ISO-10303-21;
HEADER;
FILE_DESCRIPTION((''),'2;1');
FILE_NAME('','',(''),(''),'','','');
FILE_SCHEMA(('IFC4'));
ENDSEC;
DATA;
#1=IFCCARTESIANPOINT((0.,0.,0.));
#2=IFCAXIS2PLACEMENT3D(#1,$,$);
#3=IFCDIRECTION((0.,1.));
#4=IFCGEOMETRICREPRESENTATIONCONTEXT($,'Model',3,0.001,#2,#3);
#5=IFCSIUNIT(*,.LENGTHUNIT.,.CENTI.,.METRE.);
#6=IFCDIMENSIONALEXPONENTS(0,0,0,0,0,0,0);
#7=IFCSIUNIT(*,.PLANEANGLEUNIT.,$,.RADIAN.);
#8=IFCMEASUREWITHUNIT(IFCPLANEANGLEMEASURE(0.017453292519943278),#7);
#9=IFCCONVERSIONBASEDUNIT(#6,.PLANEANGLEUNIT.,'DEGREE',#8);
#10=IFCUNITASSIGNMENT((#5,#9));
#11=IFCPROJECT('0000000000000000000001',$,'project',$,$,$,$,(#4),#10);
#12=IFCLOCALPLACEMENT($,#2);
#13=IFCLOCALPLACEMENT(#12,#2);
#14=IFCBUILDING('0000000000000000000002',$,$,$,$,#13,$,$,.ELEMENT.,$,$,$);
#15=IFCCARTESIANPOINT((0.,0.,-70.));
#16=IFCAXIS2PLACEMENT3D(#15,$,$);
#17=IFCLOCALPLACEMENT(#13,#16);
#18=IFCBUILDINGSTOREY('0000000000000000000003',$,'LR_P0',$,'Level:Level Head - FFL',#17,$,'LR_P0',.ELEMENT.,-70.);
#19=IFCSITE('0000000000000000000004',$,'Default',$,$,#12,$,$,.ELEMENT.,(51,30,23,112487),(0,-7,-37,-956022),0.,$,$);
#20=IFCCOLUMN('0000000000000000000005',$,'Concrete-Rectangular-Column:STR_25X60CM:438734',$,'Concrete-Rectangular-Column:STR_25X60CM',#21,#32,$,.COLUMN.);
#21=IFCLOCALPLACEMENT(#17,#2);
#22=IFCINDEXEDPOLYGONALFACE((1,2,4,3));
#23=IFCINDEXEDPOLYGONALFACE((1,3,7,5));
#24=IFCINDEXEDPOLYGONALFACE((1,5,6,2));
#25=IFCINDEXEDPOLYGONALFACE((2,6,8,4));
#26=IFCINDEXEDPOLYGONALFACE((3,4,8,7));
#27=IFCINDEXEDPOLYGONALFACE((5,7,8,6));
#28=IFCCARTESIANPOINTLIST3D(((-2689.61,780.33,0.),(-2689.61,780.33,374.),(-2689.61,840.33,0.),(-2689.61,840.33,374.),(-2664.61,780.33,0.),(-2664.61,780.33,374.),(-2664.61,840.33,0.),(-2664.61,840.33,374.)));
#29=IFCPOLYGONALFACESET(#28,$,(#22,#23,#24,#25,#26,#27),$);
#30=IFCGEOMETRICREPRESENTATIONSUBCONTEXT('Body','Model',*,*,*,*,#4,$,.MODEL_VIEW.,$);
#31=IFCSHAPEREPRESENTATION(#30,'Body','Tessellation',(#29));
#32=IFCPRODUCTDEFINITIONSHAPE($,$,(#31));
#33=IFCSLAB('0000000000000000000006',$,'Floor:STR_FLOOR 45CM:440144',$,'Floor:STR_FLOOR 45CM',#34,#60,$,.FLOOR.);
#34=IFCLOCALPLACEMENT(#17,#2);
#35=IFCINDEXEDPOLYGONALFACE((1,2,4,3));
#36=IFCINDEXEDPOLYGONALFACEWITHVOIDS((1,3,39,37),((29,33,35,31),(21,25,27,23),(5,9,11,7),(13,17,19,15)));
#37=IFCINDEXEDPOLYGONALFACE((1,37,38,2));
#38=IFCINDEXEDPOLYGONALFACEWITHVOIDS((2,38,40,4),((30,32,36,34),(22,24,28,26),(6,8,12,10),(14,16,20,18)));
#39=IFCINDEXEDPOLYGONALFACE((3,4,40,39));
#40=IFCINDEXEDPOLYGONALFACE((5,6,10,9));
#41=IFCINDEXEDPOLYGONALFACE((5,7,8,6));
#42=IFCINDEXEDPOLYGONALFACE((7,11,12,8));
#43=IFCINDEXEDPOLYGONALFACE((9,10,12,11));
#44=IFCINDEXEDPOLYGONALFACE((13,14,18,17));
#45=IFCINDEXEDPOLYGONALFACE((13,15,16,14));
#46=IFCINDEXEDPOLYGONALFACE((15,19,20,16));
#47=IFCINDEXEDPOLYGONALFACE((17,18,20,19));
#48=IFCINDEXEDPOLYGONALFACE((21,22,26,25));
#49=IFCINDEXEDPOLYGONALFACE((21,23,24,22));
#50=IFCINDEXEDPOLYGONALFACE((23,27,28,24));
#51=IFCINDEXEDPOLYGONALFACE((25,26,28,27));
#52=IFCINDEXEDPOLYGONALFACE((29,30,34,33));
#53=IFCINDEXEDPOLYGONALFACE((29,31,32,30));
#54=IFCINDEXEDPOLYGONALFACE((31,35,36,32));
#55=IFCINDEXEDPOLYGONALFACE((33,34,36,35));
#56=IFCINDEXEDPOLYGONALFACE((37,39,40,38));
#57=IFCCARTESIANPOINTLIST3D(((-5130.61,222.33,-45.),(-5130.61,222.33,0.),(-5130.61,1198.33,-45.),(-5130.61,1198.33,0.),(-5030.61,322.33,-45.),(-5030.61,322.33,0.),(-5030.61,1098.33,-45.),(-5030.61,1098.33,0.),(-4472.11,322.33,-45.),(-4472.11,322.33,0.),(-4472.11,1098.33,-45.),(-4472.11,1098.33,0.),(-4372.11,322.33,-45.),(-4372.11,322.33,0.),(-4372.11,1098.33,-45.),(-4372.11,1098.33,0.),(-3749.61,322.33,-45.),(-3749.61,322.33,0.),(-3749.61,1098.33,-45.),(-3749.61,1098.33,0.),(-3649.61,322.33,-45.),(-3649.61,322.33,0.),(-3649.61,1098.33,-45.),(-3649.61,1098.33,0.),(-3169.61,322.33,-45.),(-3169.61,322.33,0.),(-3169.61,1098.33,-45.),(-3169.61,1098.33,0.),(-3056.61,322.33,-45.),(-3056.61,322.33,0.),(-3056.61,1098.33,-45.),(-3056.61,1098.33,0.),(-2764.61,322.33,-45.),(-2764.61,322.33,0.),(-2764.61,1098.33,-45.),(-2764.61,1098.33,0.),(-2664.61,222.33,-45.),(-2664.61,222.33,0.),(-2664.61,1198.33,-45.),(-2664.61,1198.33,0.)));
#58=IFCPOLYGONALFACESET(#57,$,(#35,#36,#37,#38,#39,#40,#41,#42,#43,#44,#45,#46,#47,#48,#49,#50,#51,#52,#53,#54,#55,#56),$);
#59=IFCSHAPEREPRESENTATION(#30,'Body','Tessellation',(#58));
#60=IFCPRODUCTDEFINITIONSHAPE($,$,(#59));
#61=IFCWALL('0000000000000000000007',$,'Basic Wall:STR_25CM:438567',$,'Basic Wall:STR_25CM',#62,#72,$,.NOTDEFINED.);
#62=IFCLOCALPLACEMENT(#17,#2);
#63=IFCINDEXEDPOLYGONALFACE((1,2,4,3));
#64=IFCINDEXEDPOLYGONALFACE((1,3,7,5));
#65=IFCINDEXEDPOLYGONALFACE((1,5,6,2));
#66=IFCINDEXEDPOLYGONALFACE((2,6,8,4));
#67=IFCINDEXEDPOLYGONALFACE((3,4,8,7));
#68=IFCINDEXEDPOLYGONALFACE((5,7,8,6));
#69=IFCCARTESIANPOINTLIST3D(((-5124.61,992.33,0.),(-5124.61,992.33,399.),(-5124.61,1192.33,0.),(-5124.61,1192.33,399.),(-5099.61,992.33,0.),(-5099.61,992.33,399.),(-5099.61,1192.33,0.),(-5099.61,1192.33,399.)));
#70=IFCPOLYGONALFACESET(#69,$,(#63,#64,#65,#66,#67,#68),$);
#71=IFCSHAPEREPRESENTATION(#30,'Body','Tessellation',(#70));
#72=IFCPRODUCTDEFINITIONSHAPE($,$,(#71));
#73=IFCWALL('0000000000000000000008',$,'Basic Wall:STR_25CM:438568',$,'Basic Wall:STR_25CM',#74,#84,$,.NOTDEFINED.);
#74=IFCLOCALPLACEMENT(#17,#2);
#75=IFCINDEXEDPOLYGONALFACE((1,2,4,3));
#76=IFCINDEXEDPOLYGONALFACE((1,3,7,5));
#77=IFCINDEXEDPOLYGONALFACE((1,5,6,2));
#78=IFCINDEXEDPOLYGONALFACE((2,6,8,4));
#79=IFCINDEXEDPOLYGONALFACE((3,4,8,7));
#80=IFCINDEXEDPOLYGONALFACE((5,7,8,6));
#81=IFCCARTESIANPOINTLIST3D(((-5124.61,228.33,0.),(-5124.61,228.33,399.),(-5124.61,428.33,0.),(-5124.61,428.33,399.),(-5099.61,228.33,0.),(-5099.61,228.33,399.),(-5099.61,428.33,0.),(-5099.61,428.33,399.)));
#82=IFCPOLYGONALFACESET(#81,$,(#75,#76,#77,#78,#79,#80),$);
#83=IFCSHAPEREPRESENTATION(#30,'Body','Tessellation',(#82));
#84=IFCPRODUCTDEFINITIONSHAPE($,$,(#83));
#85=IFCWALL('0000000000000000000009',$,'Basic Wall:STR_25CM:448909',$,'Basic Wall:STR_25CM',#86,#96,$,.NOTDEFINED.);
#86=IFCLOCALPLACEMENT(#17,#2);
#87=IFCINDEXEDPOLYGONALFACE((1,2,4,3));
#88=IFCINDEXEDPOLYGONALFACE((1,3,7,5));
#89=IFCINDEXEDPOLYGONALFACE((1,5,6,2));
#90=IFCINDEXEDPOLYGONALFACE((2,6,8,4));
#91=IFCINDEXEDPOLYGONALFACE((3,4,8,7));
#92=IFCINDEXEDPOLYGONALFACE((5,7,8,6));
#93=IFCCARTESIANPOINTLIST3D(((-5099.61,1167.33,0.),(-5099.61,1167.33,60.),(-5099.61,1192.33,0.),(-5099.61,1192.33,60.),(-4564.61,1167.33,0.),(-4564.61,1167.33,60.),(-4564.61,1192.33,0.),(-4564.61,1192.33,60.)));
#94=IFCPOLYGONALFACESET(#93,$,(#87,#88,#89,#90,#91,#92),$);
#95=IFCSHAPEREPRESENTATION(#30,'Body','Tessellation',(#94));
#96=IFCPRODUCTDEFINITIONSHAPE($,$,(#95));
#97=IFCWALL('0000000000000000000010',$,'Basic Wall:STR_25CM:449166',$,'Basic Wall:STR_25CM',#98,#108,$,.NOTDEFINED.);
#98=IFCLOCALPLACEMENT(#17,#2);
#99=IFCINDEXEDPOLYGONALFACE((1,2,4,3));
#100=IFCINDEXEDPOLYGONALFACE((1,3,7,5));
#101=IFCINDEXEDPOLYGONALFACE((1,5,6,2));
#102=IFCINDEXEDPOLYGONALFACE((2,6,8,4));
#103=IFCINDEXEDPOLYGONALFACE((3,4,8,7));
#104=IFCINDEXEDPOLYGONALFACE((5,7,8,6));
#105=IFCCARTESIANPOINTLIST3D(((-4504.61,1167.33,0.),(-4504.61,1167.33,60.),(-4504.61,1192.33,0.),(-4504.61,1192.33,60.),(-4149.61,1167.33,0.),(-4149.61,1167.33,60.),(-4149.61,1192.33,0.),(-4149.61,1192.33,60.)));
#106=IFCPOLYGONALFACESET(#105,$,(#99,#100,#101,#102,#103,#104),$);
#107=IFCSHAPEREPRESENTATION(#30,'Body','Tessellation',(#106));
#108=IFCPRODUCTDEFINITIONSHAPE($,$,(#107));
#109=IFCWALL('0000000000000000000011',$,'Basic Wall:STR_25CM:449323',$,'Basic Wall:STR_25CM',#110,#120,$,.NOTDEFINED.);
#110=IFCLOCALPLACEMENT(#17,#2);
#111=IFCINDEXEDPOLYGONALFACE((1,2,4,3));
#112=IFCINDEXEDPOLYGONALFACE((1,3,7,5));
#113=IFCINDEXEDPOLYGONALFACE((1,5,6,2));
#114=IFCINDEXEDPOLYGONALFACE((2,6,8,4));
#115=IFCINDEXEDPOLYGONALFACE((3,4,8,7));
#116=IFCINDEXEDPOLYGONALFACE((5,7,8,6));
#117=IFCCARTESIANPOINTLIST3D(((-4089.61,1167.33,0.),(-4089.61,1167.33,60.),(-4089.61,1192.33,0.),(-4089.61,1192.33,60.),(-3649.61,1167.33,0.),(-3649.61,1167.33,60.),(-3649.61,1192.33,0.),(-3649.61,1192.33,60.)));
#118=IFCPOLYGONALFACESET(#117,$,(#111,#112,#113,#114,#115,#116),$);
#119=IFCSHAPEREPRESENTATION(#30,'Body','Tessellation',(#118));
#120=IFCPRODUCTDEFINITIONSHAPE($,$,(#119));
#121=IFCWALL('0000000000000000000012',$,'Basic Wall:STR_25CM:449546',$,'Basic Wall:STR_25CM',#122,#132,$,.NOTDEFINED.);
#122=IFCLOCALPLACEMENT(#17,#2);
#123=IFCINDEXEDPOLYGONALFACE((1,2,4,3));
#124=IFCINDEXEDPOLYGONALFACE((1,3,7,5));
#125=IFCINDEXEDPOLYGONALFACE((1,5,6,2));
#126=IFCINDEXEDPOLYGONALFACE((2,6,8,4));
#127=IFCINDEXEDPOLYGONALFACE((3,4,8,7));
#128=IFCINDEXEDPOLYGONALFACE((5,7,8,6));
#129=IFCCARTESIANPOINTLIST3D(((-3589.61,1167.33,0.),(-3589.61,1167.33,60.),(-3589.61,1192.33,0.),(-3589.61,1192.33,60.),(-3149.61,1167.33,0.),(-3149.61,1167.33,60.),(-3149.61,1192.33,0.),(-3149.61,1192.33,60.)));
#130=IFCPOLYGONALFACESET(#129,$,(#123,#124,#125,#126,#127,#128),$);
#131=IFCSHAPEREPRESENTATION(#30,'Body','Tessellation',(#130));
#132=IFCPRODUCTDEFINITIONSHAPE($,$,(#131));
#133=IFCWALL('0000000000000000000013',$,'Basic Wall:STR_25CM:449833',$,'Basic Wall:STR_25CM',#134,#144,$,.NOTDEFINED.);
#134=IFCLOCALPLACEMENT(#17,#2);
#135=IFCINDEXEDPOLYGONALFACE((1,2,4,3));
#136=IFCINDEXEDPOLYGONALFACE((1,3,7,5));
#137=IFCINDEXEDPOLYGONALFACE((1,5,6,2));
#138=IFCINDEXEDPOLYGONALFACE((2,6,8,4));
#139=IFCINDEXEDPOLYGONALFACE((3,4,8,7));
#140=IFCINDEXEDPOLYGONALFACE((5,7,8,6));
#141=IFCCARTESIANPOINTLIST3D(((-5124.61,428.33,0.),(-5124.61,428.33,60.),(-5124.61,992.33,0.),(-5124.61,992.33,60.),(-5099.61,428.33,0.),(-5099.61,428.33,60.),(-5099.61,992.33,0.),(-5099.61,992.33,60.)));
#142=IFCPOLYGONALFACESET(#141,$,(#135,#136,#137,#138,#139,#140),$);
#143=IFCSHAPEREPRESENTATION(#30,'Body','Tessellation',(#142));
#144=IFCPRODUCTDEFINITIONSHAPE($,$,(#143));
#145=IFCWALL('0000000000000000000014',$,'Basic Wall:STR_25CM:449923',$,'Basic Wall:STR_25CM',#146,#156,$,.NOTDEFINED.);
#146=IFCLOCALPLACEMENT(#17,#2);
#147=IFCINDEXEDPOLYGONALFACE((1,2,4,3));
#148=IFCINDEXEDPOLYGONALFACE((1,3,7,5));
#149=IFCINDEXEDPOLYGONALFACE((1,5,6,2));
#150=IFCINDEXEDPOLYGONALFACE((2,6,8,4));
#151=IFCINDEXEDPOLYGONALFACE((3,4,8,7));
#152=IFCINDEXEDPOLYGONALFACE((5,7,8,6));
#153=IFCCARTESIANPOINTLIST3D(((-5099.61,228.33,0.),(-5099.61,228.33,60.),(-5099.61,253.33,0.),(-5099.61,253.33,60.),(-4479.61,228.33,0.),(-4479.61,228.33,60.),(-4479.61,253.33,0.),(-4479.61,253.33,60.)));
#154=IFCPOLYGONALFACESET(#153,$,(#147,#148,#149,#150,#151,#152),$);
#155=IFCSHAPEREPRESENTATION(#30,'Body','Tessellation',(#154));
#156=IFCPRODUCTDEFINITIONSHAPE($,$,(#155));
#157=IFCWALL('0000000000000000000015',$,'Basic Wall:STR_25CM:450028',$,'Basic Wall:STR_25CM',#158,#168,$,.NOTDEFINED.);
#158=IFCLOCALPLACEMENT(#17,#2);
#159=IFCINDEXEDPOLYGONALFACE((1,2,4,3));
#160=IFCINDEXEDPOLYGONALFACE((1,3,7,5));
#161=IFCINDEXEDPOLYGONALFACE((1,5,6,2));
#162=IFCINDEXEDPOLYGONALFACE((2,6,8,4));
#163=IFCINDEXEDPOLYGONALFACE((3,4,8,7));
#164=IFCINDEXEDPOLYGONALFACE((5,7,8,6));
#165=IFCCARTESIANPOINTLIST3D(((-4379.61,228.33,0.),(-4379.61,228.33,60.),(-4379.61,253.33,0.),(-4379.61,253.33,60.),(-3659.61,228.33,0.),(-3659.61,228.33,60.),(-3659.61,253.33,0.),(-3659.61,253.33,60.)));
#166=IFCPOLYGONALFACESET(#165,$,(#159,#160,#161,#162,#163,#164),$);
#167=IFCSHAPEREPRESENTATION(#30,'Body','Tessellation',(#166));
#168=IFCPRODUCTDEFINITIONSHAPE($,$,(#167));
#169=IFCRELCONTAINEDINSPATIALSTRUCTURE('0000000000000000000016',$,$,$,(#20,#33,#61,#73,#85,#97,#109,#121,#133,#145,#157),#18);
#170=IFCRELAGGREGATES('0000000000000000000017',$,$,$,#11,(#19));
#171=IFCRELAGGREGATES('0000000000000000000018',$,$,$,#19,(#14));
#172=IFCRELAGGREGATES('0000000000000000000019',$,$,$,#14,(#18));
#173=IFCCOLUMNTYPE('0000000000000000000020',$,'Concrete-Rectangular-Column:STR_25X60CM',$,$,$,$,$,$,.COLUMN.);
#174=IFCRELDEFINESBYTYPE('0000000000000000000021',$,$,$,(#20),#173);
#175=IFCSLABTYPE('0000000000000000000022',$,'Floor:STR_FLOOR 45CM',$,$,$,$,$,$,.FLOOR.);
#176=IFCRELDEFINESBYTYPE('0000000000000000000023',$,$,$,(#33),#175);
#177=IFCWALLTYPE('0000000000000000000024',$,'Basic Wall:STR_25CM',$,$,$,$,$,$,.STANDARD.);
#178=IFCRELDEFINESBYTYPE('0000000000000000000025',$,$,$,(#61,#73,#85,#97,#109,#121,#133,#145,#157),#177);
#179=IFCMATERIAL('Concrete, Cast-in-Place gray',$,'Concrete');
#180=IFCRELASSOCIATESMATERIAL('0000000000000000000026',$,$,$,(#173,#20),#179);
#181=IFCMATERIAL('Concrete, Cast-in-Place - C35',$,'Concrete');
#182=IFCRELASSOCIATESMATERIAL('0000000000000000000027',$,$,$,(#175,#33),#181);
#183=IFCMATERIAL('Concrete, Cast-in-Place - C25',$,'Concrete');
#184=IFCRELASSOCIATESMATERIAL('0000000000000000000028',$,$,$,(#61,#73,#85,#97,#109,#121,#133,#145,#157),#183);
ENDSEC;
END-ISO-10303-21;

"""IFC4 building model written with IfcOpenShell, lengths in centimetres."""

from ifc_helpers import new_model, entity, si_unit, converted_unit, direction, frame, origin, place, context, subcontext, project, spatial, indexed_curve, outline, extrude, source, transform, mapped, material, type_object, type_shapes, element, save


model = new_model("IFC4")

# Units and contexts
model_context = context("Model", 3, precision=0.001, world=origin(), true_north=direction((0.0, 1.0)))
body_context = subcontext(model_context, "Body", "Model", "MODEL_VIEW")
ifc_project = project(units=[si_unit("LENGTHUNIT", "METRE", prefix="CENTI"), converted_unit("PLANEANGLEUNIT", "DEGREE", entity("IfcPlaneAngleMeasure", 0.017453292519943278), si_unit("PLANEANGLEUNIT", "RADIAN"), dimensions=[0, 0, 0, 0, 0, 0, 0])], contexts=[model_context])

# Site, building, storey
site_placement = place(None, origin())
site = spatial("IfcSite", under=ifc_project, at=site_placement, Name="Default", CompositionType="ELEMENT", RefLatitude=(51, 30, 23, 112487), RefLongitude=(0, -7, -37, -956022), RefElevation=0.0)
building_placement = place(site_placement, origin())
building = spatial("IfcBuilding", under=site, at=building_placement, CompositionType="ELEMENT")
storey_placement = place(building_placement, frame((0.0, 0.0, -70.0)))
storey = spatial("IfcBuildingStorey", under=building, at=storey_placement, Name="LR_P0", ObjectType="Level:Level Head - FFL", LongName="LR_P0", CompositionType="ELEMENT", Elevation=-70.0)

# Column
ifc_material_1 = material(Name="Concrete, Cast-in-Place gray", Category="Concrete")
column_type_1 = type_object("IfcColumnType", Name="Concrete-Rectangular-Column:STR_25X60CM", PredefinedType="COLUMN", material=ifc_material_1)
shared_shape_1 = source(origin(), body_context, "Body", "SweptSolid", [
    extrude(outline(indexed_curve([(-12.5, -30.0), (12.5, -30.0), (12.5, 30.0), (-12.5, 30.0), (-12.5, -30.0)], self_intersect=False)), frame((-2677.11, 810.33, -70.0), z_axis=(0.0, 0.0, 1.0), x_axis=(-1.0, 0.0, 0.0)), (0.0, 0.0, 1.0), 374.0),
])
type_shapes(column_type_1, [shared_shape_1])
column_1_placement = place(storey_placement, frame((0.0, 0.0, 70.0)))
element("IfcColumn", 1, at=column_1_placement, inside=storey, type_object=column_type_1, material=ifc_material_1, Name="Concrete-Rectangular-Column:STR_25X60CM:438734", ObjectType="Concrete-Rectangular-Column:STR_25X60CM", PredefinedType="COLUMN", context=body_context, shape_type="MappedRepresentation", body=[
    mapped(shared_shape_1, transform((0.0, 0.0, 0.0), scale=1.0)),
])

# Slab, openings
ifc_material_2 = material(Name="Concrete, Cast-in-Place - C35", Category="Concrete")
slab_type = type_object("IfcSlabType", Name="Floor:STR_FLOOR 45CM", PredefinedType="FLOOR", material=ifc_material_2)
slab_placement = place(storey_placement, origin())
slab = element("IfcSlab", 2, at=slab_placement, inside=storey, type_object=slab_type, material=ifc_material_2, Name="Floor:STR_FLOOR 45CM:440144", ObjectType="Floor:STR_FLOOR 45CM", PredefinedType="FLOOR", context=body_context, shape_type="SweptSolid", body=[
    extrude(outline(indexed_curve([(-488.0, -1233.0), (488.0, -1233.0), (488.0, 1233.0), (-488.0, 1233.0), (-488.0, -1233.0)], self_intersect=False), holes=[indexed_curve([(388.0, -1133.0), (-388.0, -1133.0), (-388.0, -574.5), (388.0, -574.5), (388.0, -1133.0)], self_intersect=False), indexed_curve([(-388.0, 841.0), (-388.0, 1133.0), (388.0, 1133.0), (388.0, 841.0), (-388.0, 841.0)], self_intersect=False), indexed_curve([(388.0, -474.5), (-388.0, -474.5), (-388.0, 148.0), (388.0, 148.0), (388.0, -474.5)], self_intersect=False), indexed_curve([(-388.0, 728.0), (388.0, 728.0), (388.0, 248.0), (-388.0, 248.0), (-388.0, 728.0)], self_intersect=False)]), frame((-3897.61, 710.33, -45.0), z_axis=(0.0, 0.0, 1.0), x_axis=(0.0, -1.0, 0.0)), (0.0, 0.0, 1.0), 45.0),
])
opening_1_placement = place(slab_placement, origin())
element("IfcOpeningElement", 3, at=opening_1_placement, cuts=slab, PredefinedType="OPENING", context=body_context, shape_type="SweptSolid", body=[
    extrude(outline(indexed_curve([(-5030.61, 322.33), (-4472.11, 322.33), (-4472.11, 1098.33), (-5030.61, 1098.33), (-5030.61, 322.33)], self_intersect=False)), frame((0.0, 0.0, 70.0)), (0.0, 0.0, -1.0), 2466.0),
])
opening_2_placement = place(slab_placement, origin())
element("IfcOpeningElement", 4, at=opening_2_placement, cuts=slab, PredefinedType="OPENING", context=body_context, shape_type="SweptSolid", body=[
    extrude(outline(indexed_curve([(-3056.61, 1098.33), (-3056.61, 322.33), (-2764.61, 322.33), (-2764.61, 1098.33), (-3056.61, 1098.33)], self_intersect=False)), frame((0.0, 0.0, 70.0)), (0.0, 0.0, -1.0), 2466.0),
])
opening_3_placement = place(slab_placement, origin())
element("IfcOpeningElement", 5, at=opening_3_placement, cuts=slab, PredefinedType="OPENING", context=body_context, shape_type="SweptSolid", body=[
    extrude(outline(indexed_curve([(-4372.11, 322.33), (-3749.61, 322.33), (-3749.61, 1098.33), (-4372.11, 1098.33), (-4372.11, 322.33)], self_intersect=False)), frame((0.0, 0.0, 70.0)), (0.0, 0.0, -1.0), 2466.0),
])
opening_4_placement = place(slab_placement, origin())
element("IfcOpeningElement", 6, at=opening_4_placement, cuts=slab, PredefinedType="OPENING", context=body_context, shape_type="SweptSolid", body=[
    extrude(outline(indexed_curve([(-3169.61, 1098.33), (-3649.61, 1098.33), (-3649.61, 322.33), (-3169.61, 322.33), (-3169.61, 1098.33)], self_intersect=False)), frame((0.0, 0.0, 70.0)), (0.0, 0.0, -1.0), 2466.0),
])

# Walls
ifc_material_3 = material(Name="Concrete, Cast-in-Place - C25", Category="Concrete")
wall_type = type_object("IfcWallType", Name="Basic Wall:STR_25CM", PredefinedType="STANDARD")
wall_1_placement = place(storey_placement, frame((-5112.11, 992.33, 0.0), z_axis=(0.0, 0.0, 1.0), x_axis=(0.0, 1.0, 0.0)))
element("IfcWall", 7, at=wall_1_placement, inside=storey, type_object=wall_type, material=ifc_material_3, Name="Basic Wall:STR_25CM:438567", ObjectType="Basic Wall:STR_25CM", PredefinedType="NOTDEFINED", context=body_context, shape_type="SweptSolid", body=[
    extrude(outline(indexed_curve([(200.0, 12.5), (0.0, 12.5), (0.0, -12.5), (200.0, -12.5), (200.0, 12.5)], self_intersect=False)), origin(), (0.0, 0.0, 1.0), 399.0),
])
wall_2_placement = place(storey_placement, frame((-5112.11, 228.33, 0.0), z_axis=(0.0, 0.0, 1.0), x_axis=(0.0, 1.0, 0.0)))
element("IfcWall", 8, at=wall_2_placement, inside=storey, type_object=wall_type, material=ifc_material_3, Name="Basic Wall:STR_25CM:438568", ObjectType="Basic Wall:STR_25CM", PredefinedType="NOTDEFINED", context=body_context, shape_type="SweptSolid", body=[
    extrude(outline(indexed_curve([(200.0, 12.5), (0.0, 12.5), (0.0, -12.5), (200.0, -12.5), (200.0, 12.5)], self_intersect=False)), origin(), (0.0, 0.0, 1.0), 399.0),
])
wall_3_placement = place(storey_placement, frame((-5099.61, 1179.83, 0.0)))
element("IfcWall", 9, at=wall_3_placement, inside=storey, type_object=wall_type, material=ifc_material_3, Name="Basic Wall:STR_25CM:448909", ObjectType="Basic Wall:STR_25CM", PredefinedType="NOTDEFINED", context=body_context, shape_type="SweptSolid", body=[
    extrude(outline(indexed_curve([(535.0, 12.5), (0.0, 12.5), (0.0, -12.5), (535.0, -12.5), (535.0, 12.5)], self_intersect=False)), origin(), (0.0, 0.0, 1.0), 60.0),
])
wall_4_placement = place(storey_placement, frame((-4504.61, 1179.83, 0.0)))
element("IfcWall", 10, at=wall_4_placement, inside=storey, type_object=wall_type, material=ifc_material_3, Name="Basic Wall:STR_25CM:449166", ObjectType="Basic Wall:STR_25CM", PredefinedType="NOTDEFINED", context=body_context, shape_type="SweptSolid", body=[
    extrude(outline(indexed_curve([(355.0, 12.5), (0.0, 12.5), (0.0, -12.5), (355.0, -12.5), (355.0, 12.5)], self_intersect=False)), origin(), (0.0, 0.0, 1.0), 60.0),
])
for number, where, name in (
    (11, (-4089.61, 1179.83, 0.0), "Basic Wall:STR_25CM:449323"),
    (12, (-3589.61, 1179.83, 0.0), "Basic Wall:STR_25CM:449546"),
):
    element("IfcWall", number, at=place(storey_placement, frame(where)), inside=storey, type_object=wall_type, material=ifc_material_3, Name=name, ObjectType="Basic Wall:STR_25CM", PredefinedType="NOTDEFINED", context=body_context, shape_type="SweptSolid", body=[
        extrude(outline(indexed_curve([(440.0, 12.5), (0.0, 12.5), (0.0, -12.5), (440.0, -12.5), (440.0, 12.5)], self_intersect=False)), origin(), (0.0, 0.0, 1.0), 60.0),
    ])
wall_5_placement = place(storey_placement, frame((-5112.11, 992.33, 0.0), z_axis=(0.0, 0.0, 1.0), x_axis=(0.0, -1.0, 0.0)))
element("IfcWall", 13, at=wall_5_placement, inside=storey, type_object=wall_type, material=ifc_material_3, Name="Basic Wall:STR_25CM:449833", ObjectType="Basic Wall:STR_25CM", PredefinedType="NOTDEFINED", context=body_context, shape_type="SweptSolid", body=[
    extrude(outline(indexed_curve([(564.0, 12.5), (0.0, 12.5), (0.0, -12.5), (564.0, -12.5), (564.0, 12.5)], self_intersect=False)), origin(), (0.0, 0.0, 1.0), 60.0),
])
wall_6_placement = place(storey_placement, frame((-5099.61, 240.83, 0.0)))
element("IfcWall", 14, at=wall_6_placement, inside=storey, type_object=wall_type, material=ifc_material_3, Name="Basic Wall:STR_25CM:449923", ObjectType="Basic Wall:STR_25CM", PredefinedType="NOTDEFINED", context=body_context, shape_type="SweptSolid", body=[
    extrude(outline(indexed_curve([(620.0, 12.5), (0.0, 12.5), (0.0, -12.5), (620.0, -12.5), (620.0, 12.5)], self_intersect=False)), origin(), (0.0, 0.0, 1.0), 60.0),
])
wall_7_placement = place(storey_placement, frame((-4379.61, 240.83, 0.0)))
element("IfcWall", 15, at=wall_7_placement, inside=storey, type_object=wall_type, material=ifc_material_3, Name="Basic Wall:STR_25CM:450028", ObjectType="Basic Wall:STR_25CM", PredefinedType="NOTDEFINED", context=body_context, shape_type="SweptSolid", body=[
    extrude(outline(indexed_curve([(720.0, 12.5), (0.0, 12.5), (0.0, -12.5), (720.0, -12.5), (720.0, 12.5)], self_intersect=False)), origin(), (0.0, 0.0, 1.0), 60.0),
])

save(model, "model.ifc")
